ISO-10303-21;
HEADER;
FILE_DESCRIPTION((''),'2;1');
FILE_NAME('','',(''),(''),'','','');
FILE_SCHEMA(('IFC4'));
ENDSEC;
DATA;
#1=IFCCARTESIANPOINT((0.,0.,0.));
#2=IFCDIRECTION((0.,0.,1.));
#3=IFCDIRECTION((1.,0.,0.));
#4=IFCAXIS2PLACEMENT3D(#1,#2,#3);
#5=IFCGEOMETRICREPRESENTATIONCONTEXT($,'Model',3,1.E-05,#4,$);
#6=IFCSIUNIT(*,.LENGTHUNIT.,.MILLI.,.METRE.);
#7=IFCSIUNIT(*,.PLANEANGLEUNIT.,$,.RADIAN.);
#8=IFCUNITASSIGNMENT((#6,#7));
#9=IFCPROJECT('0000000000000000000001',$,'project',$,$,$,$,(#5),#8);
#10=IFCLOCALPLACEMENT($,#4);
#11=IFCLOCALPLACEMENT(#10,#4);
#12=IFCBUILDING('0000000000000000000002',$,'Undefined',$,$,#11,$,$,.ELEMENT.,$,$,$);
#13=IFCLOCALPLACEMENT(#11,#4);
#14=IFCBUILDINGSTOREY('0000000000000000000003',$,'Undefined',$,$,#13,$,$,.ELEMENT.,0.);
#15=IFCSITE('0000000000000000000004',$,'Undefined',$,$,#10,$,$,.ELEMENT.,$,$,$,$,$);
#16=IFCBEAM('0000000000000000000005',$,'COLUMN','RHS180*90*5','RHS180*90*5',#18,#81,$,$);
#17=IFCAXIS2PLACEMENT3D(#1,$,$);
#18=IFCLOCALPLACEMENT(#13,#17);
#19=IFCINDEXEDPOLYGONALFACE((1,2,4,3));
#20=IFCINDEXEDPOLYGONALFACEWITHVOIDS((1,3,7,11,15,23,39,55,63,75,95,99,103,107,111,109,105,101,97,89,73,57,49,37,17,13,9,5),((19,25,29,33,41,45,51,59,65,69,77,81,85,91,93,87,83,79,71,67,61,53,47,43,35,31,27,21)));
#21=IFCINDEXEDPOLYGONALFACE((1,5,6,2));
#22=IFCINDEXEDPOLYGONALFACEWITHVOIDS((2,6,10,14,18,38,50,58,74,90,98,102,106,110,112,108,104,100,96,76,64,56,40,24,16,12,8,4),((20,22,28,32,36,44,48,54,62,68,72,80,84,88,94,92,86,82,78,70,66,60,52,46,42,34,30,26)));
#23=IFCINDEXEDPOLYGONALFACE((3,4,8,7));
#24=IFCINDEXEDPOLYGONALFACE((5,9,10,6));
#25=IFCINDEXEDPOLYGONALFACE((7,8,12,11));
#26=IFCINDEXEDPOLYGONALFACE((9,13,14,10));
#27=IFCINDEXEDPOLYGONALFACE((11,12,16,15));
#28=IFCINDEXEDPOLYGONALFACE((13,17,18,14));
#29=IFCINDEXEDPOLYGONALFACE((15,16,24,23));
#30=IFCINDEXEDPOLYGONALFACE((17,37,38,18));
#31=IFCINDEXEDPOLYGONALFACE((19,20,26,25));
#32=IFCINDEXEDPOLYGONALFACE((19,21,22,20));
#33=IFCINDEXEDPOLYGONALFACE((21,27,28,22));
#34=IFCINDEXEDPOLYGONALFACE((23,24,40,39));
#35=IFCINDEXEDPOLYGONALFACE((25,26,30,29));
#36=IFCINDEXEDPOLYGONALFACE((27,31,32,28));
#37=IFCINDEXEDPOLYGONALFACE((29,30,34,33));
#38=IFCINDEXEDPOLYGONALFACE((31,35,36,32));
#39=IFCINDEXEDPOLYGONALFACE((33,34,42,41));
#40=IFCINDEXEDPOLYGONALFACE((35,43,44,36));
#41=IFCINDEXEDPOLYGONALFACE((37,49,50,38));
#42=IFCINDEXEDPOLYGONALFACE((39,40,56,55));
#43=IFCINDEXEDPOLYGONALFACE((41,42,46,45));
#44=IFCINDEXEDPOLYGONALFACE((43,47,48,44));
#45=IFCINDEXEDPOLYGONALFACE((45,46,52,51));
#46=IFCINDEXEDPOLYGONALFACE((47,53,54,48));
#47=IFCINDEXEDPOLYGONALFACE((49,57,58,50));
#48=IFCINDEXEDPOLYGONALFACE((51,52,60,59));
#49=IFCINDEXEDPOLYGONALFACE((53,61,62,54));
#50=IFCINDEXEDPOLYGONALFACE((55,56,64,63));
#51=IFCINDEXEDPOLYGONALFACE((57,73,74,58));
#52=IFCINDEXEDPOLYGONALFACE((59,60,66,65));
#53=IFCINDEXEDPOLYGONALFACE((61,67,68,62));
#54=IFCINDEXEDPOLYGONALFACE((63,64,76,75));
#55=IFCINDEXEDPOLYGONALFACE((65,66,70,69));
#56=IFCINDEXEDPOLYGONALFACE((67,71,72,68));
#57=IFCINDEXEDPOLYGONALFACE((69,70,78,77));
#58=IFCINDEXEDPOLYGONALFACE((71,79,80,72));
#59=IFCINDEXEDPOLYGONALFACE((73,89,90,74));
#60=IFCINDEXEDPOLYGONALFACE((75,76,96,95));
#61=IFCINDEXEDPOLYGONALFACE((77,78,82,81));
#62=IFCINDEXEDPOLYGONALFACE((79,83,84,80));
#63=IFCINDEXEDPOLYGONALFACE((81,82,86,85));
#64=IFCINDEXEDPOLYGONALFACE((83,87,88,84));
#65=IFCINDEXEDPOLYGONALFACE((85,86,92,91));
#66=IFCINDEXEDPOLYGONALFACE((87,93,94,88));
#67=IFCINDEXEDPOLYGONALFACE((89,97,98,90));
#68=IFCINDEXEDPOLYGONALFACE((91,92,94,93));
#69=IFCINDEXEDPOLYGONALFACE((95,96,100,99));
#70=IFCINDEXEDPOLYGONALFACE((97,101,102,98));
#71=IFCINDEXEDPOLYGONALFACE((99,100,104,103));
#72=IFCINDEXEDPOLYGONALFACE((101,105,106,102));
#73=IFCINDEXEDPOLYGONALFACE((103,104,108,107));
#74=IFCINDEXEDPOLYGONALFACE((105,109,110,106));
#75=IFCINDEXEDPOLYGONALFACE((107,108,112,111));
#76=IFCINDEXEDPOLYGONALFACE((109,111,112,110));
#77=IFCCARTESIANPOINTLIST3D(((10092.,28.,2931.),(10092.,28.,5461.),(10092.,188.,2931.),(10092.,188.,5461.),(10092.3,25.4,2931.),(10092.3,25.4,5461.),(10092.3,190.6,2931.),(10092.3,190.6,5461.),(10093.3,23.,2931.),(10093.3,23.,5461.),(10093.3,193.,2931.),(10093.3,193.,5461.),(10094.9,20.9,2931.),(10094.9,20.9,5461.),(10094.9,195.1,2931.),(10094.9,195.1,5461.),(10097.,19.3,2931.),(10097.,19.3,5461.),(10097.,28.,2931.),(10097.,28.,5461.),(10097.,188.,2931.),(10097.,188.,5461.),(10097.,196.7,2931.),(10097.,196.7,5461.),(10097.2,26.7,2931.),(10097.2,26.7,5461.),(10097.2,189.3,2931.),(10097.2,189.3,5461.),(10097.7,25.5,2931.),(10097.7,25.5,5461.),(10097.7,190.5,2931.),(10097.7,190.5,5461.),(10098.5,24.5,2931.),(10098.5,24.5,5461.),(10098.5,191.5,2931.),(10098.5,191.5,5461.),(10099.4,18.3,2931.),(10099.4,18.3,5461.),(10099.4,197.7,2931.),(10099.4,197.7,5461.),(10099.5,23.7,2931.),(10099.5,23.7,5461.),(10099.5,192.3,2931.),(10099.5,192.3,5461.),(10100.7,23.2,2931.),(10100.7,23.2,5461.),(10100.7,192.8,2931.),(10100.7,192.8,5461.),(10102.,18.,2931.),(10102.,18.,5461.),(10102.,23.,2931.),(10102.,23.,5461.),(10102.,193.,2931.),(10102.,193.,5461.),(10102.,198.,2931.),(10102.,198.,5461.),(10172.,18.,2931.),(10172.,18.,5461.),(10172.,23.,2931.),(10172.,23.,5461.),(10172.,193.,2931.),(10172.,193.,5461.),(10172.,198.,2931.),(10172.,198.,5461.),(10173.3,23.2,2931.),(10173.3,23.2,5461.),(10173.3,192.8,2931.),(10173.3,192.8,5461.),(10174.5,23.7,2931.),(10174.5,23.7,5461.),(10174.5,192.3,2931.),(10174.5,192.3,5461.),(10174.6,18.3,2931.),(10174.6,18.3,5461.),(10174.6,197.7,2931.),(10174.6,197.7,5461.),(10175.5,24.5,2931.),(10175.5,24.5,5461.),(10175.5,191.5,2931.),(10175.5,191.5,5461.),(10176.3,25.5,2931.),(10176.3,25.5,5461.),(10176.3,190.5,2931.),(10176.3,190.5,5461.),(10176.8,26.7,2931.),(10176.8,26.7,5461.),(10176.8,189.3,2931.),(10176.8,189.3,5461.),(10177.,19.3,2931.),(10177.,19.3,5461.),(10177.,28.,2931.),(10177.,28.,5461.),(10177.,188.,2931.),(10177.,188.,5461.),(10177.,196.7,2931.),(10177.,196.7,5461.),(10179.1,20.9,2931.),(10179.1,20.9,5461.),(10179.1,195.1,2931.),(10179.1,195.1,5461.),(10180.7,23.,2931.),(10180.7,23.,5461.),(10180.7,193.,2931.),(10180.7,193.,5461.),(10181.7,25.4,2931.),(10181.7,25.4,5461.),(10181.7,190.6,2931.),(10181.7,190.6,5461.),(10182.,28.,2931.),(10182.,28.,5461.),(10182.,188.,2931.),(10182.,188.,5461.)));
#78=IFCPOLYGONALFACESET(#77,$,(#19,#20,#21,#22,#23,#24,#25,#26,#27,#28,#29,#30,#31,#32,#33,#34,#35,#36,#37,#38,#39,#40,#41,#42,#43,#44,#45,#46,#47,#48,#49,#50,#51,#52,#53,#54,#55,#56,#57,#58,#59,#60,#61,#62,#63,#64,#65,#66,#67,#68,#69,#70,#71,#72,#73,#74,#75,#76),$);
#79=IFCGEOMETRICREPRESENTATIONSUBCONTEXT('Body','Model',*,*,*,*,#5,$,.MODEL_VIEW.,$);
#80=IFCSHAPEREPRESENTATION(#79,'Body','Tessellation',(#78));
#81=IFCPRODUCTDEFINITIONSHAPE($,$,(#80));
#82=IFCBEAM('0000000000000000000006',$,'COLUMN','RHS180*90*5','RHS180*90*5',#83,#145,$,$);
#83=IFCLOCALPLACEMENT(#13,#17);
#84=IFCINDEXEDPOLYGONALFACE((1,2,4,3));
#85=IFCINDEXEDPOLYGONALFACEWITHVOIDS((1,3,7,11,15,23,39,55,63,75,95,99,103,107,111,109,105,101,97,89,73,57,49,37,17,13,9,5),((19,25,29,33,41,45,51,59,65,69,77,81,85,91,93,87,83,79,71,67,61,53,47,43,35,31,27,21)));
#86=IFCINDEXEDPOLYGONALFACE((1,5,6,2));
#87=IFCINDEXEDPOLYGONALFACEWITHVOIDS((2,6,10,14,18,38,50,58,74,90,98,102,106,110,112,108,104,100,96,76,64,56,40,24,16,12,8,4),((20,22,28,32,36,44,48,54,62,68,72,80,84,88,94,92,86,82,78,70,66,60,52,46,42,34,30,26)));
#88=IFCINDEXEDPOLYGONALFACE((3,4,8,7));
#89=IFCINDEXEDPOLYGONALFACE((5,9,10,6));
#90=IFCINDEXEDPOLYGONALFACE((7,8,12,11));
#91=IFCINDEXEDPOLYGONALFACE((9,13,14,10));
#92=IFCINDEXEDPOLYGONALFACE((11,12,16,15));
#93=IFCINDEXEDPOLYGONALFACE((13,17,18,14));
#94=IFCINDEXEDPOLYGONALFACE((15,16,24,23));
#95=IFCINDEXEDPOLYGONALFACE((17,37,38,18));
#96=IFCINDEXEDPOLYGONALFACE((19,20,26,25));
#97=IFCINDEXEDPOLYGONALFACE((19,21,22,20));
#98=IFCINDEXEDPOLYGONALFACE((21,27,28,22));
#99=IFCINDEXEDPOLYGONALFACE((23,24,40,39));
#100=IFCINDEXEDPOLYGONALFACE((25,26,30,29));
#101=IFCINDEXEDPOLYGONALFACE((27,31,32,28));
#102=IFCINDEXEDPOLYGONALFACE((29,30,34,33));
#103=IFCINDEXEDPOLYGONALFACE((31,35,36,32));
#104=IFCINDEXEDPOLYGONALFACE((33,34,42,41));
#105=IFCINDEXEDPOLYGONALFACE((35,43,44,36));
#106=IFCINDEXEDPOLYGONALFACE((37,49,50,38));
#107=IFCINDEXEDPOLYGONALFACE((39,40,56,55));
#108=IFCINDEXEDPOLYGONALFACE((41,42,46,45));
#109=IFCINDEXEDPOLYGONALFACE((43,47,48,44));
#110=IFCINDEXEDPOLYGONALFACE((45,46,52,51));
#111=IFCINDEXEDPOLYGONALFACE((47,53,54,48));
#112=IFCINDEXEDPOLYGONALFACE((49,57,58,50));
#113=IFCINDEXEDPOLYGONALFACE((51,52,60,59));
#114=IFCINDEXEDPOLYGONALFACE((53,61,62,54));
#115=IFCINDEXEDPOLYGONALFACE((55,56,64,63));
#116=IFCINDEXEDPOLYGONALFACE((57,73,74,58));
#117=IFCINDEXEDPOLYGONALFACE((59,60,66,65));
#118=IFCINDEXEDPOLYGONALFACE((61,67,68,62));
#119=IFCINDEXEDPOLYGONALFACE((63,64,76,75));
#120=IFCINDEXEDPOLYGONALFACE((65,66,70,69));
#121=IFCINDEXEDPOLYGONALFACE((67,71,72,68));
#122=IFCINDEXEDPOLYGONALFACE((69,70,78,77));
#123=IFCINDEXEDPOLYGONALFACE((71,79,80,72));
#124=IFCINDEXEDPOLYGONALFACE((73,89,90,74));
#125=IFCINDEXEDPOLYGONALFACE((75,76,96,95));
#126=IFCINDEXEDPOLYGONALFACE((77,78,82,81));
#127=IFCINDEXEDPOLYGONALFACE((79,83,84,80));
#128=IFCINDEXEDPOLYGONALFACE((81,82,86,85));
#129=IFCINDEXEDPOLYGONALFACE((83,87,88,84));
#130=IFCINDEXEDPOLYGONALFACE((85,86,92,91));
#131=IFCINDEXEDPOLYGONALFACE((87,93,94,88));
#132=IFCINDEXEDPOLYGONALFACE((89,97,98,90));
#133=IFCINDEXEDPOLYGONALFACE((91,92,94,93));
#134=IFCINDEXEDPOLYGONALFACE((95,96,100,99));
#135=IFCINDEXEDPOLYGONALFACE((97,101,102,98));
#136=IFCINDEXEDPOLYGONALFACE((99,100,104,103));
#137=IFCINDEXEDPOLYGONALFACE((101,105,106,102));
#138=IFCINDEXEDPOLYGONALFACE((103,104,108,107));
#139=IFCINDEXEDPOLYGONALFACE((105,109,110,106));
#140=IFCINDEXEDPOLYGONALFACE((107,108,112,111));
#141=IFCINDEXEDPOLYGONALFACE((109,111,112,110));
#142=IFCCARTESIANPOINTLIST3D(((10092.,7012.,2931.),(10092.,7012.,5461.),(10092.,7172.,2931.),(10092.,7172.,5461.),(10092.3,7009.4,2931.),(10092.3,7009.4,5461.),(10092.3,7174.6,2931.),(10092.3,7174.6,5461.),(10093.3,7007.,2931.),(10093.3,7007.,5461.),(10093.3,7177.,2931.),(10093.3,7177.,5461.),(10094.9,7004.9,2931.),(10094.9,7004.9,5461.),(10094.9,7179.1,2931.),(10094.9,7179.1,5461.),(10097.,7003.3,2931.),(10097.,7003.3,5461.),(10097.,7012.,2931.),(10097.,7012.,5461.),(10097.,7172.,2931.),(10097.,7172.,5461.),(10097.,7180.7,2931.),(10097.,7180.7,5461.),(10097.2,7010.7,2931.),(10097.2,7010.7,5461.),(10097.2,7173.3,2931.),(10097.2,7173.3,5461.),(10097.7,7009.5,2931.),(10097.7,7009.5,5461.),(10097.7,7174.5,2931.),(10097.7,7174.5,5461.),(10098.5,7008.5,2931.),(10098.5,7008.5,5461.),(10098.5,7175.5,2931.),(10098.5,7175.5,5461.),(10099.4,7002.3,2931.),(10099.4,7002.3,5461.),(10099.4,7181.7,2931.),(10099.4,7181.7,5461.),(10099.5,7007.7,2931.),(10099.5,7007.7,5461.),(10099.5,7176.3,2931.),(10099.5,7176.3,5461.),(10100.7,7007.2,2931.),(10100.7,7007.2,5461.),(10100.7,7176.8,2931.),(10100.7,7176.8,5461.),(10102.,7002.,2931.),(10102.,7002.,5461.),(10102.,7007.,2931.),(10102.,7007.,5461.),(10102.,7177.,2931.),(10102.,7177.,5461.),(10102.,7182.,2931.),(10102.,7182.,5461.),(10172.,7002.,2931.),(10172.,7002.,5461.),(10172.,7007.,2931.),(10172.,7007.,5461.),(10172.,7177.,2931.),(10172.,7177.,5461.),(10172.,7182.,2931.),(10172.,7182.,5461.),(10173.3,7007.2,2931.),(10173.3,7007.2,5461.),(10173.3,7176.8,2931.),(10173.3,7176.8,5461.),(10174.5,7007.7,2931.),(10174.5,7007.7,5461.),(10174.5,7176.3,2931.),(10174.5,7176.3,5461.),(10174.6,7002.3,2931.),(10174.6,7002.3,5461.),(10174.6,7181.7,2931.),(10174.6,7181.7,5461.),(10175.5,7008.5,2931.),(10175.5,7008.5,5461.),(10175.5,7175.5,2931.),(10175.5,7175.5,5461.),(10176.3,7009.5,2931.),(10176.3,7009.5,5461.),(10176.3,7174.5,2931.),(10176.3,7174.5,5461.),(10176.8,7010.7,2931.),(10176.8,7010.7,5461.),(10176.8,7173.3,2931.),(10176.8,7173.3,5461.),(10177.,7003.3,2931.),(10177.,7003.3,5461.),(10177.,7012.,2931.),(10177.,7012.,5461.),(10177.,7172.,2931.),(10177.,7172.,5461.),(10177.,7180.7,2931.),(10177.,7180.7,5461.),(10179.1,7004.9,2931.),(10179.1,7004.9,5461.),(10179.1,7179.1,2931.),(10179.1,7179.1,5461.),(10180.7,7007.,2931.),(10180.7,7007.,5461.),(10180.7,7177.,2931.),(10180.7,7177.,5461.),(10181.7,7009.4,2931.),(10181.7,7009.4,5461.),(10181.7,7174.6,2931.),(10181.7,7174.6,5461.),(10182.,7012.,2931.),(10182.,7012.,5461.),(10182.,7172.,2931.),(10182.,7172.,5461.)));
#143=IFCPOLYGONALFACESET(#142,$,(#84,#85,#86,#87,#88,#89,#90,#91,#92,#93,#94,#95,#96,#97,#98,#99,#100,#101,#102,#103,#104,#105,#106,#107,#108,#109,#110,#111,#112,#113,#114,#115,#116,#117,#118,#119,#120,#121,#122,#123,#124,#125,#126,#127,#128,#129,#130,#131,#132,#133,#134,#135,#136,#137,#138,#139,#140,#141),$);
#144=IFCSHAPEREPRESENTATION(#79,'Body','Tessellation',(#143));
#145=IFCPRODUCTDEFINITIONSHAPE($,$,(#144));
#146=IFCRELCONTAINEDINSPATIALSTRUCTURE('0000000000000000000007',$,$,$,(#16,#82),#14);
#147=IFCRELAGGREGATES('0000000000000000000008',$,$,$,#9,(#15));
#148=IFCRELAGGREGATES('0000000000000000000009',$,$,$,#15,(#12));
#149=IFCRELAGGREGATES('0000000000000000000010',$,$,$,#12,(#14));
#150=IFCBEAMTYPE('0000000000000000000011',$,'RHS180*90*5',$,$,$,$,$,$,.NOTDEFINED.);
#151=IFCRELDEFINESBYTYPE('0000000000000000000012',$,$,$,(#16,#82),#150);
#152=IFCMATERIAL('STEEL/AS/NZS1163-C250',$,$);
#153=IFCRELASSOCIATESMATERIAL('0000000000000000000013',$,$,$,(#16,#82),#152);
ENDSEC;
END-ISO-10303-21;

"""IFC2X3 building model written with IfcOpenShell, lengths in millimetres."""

from ifc_helpers import new_model, si_unit, frame, origin_with_axes, origin_2d_with_axis, place, context, subcontext, project, spatial, hollow_rectangle, extrude, material, type_object, element, save


model = new_model("IFC2X3")

# Units and contexts
model_context = context("Model", 3, precision=1e-05, world=origin_with_axes())
body_context = subcontext(model_context, "Body", "Model", "MODEL_VIEW")
ifc_project = project(units=[si_unit("LENGTHUNIT", "METRE", prefix="MILLI"), si_unit("PLANEANGLEUNIT", "RADIAN")], contexts=[model_context])

# Site, building, storey
site_placement = place(None, origin_with_axes())
site = spatial("IfcSite", under=ifc_project, at=site_placement, Name="Undefined", CompositionType="ELEMENT")
building_placement = place(site_placement, origin_with_axes())
building = spatial("IfcBuilding", under=site, at=building_placement, Name="Undefined", CompositionType="ELEMENT")
storey_placement = place(building_placement, origin_with_axes())
storey = spatial("IfcBuildingStorey", under=building, at=storey_placement, Name="Undefined", CompositionType="ELEMENT", Elevation=0.0)

# Shared definitions
ifc_material_1 = material(Name="STEEL/AS/NZS1163-C250")

# Beams
beam_type_1 = type_object("IfcBeamType", Name="RHS180*90*5", PredefinedType="NOTDEFINED")
beam_1_placement = place(storey_placement, frame((10137.0, 108.0, 5461.0), z_axis=(0.0, 1.0, 0.0), x_axis=(0.0, 0.0, -1.0)))
element("IfcBeam", 1, at=beam_1_placement, inside=storey, type_object=beam_type_1, material=ifc_material_1, Name="COLUMN", Description="RHS180*90*5", ObjectType="RHS180*90*5", context=body_context, shape_type="SweptSolid", body=[
    extrude(hollow_rectangle(XDim=90.0, YDim=180.0, WallThickness=5.0, InnerFilletRadius=5.0, OuterFilletRadius=10.0, at=origin_2d_with_axis()), frame((2530.0, 0.0, 0.0), z_axis=(-1.0, 0.0, 0.0), x_axis=(0.0, -1.0, 0.0)), (0.0, 0.0, 1.0), 2530.0),
])
beam_2_placement = place(storey_placement, frame((10137.0, 7092.0, 5461.0), z_axis=(0.0, 1.0, 0.0), x_axis=(0.0, 0.0, -1.0)))
element("IfcBeam", 2, at=beam_2_placement, inside=storey, type_object=beam_type_1, material=ifc_material_1, Name="COLUMN", Description="RHS180*90*5", ObjectType="RHS180*90*5", context=body_context, shape_type="SweptSolid", body=[
    extrude(hollow_rectangle(XDim=90.0, YDim=180.0, WallThickness=5.0, InnerFilletRadius=5.0, OuterFilletRadius=10.0, at=origin_2d_with_axis()), frame((2530.0, 0.0, 0.0), z_axis=(-1.0, 0.0, 0.0), x_axis=(0.0, -1.0, 0.0)), (0.0, 0.0, 1.0), 2530.0),
])

save(model, "model.ifc")
